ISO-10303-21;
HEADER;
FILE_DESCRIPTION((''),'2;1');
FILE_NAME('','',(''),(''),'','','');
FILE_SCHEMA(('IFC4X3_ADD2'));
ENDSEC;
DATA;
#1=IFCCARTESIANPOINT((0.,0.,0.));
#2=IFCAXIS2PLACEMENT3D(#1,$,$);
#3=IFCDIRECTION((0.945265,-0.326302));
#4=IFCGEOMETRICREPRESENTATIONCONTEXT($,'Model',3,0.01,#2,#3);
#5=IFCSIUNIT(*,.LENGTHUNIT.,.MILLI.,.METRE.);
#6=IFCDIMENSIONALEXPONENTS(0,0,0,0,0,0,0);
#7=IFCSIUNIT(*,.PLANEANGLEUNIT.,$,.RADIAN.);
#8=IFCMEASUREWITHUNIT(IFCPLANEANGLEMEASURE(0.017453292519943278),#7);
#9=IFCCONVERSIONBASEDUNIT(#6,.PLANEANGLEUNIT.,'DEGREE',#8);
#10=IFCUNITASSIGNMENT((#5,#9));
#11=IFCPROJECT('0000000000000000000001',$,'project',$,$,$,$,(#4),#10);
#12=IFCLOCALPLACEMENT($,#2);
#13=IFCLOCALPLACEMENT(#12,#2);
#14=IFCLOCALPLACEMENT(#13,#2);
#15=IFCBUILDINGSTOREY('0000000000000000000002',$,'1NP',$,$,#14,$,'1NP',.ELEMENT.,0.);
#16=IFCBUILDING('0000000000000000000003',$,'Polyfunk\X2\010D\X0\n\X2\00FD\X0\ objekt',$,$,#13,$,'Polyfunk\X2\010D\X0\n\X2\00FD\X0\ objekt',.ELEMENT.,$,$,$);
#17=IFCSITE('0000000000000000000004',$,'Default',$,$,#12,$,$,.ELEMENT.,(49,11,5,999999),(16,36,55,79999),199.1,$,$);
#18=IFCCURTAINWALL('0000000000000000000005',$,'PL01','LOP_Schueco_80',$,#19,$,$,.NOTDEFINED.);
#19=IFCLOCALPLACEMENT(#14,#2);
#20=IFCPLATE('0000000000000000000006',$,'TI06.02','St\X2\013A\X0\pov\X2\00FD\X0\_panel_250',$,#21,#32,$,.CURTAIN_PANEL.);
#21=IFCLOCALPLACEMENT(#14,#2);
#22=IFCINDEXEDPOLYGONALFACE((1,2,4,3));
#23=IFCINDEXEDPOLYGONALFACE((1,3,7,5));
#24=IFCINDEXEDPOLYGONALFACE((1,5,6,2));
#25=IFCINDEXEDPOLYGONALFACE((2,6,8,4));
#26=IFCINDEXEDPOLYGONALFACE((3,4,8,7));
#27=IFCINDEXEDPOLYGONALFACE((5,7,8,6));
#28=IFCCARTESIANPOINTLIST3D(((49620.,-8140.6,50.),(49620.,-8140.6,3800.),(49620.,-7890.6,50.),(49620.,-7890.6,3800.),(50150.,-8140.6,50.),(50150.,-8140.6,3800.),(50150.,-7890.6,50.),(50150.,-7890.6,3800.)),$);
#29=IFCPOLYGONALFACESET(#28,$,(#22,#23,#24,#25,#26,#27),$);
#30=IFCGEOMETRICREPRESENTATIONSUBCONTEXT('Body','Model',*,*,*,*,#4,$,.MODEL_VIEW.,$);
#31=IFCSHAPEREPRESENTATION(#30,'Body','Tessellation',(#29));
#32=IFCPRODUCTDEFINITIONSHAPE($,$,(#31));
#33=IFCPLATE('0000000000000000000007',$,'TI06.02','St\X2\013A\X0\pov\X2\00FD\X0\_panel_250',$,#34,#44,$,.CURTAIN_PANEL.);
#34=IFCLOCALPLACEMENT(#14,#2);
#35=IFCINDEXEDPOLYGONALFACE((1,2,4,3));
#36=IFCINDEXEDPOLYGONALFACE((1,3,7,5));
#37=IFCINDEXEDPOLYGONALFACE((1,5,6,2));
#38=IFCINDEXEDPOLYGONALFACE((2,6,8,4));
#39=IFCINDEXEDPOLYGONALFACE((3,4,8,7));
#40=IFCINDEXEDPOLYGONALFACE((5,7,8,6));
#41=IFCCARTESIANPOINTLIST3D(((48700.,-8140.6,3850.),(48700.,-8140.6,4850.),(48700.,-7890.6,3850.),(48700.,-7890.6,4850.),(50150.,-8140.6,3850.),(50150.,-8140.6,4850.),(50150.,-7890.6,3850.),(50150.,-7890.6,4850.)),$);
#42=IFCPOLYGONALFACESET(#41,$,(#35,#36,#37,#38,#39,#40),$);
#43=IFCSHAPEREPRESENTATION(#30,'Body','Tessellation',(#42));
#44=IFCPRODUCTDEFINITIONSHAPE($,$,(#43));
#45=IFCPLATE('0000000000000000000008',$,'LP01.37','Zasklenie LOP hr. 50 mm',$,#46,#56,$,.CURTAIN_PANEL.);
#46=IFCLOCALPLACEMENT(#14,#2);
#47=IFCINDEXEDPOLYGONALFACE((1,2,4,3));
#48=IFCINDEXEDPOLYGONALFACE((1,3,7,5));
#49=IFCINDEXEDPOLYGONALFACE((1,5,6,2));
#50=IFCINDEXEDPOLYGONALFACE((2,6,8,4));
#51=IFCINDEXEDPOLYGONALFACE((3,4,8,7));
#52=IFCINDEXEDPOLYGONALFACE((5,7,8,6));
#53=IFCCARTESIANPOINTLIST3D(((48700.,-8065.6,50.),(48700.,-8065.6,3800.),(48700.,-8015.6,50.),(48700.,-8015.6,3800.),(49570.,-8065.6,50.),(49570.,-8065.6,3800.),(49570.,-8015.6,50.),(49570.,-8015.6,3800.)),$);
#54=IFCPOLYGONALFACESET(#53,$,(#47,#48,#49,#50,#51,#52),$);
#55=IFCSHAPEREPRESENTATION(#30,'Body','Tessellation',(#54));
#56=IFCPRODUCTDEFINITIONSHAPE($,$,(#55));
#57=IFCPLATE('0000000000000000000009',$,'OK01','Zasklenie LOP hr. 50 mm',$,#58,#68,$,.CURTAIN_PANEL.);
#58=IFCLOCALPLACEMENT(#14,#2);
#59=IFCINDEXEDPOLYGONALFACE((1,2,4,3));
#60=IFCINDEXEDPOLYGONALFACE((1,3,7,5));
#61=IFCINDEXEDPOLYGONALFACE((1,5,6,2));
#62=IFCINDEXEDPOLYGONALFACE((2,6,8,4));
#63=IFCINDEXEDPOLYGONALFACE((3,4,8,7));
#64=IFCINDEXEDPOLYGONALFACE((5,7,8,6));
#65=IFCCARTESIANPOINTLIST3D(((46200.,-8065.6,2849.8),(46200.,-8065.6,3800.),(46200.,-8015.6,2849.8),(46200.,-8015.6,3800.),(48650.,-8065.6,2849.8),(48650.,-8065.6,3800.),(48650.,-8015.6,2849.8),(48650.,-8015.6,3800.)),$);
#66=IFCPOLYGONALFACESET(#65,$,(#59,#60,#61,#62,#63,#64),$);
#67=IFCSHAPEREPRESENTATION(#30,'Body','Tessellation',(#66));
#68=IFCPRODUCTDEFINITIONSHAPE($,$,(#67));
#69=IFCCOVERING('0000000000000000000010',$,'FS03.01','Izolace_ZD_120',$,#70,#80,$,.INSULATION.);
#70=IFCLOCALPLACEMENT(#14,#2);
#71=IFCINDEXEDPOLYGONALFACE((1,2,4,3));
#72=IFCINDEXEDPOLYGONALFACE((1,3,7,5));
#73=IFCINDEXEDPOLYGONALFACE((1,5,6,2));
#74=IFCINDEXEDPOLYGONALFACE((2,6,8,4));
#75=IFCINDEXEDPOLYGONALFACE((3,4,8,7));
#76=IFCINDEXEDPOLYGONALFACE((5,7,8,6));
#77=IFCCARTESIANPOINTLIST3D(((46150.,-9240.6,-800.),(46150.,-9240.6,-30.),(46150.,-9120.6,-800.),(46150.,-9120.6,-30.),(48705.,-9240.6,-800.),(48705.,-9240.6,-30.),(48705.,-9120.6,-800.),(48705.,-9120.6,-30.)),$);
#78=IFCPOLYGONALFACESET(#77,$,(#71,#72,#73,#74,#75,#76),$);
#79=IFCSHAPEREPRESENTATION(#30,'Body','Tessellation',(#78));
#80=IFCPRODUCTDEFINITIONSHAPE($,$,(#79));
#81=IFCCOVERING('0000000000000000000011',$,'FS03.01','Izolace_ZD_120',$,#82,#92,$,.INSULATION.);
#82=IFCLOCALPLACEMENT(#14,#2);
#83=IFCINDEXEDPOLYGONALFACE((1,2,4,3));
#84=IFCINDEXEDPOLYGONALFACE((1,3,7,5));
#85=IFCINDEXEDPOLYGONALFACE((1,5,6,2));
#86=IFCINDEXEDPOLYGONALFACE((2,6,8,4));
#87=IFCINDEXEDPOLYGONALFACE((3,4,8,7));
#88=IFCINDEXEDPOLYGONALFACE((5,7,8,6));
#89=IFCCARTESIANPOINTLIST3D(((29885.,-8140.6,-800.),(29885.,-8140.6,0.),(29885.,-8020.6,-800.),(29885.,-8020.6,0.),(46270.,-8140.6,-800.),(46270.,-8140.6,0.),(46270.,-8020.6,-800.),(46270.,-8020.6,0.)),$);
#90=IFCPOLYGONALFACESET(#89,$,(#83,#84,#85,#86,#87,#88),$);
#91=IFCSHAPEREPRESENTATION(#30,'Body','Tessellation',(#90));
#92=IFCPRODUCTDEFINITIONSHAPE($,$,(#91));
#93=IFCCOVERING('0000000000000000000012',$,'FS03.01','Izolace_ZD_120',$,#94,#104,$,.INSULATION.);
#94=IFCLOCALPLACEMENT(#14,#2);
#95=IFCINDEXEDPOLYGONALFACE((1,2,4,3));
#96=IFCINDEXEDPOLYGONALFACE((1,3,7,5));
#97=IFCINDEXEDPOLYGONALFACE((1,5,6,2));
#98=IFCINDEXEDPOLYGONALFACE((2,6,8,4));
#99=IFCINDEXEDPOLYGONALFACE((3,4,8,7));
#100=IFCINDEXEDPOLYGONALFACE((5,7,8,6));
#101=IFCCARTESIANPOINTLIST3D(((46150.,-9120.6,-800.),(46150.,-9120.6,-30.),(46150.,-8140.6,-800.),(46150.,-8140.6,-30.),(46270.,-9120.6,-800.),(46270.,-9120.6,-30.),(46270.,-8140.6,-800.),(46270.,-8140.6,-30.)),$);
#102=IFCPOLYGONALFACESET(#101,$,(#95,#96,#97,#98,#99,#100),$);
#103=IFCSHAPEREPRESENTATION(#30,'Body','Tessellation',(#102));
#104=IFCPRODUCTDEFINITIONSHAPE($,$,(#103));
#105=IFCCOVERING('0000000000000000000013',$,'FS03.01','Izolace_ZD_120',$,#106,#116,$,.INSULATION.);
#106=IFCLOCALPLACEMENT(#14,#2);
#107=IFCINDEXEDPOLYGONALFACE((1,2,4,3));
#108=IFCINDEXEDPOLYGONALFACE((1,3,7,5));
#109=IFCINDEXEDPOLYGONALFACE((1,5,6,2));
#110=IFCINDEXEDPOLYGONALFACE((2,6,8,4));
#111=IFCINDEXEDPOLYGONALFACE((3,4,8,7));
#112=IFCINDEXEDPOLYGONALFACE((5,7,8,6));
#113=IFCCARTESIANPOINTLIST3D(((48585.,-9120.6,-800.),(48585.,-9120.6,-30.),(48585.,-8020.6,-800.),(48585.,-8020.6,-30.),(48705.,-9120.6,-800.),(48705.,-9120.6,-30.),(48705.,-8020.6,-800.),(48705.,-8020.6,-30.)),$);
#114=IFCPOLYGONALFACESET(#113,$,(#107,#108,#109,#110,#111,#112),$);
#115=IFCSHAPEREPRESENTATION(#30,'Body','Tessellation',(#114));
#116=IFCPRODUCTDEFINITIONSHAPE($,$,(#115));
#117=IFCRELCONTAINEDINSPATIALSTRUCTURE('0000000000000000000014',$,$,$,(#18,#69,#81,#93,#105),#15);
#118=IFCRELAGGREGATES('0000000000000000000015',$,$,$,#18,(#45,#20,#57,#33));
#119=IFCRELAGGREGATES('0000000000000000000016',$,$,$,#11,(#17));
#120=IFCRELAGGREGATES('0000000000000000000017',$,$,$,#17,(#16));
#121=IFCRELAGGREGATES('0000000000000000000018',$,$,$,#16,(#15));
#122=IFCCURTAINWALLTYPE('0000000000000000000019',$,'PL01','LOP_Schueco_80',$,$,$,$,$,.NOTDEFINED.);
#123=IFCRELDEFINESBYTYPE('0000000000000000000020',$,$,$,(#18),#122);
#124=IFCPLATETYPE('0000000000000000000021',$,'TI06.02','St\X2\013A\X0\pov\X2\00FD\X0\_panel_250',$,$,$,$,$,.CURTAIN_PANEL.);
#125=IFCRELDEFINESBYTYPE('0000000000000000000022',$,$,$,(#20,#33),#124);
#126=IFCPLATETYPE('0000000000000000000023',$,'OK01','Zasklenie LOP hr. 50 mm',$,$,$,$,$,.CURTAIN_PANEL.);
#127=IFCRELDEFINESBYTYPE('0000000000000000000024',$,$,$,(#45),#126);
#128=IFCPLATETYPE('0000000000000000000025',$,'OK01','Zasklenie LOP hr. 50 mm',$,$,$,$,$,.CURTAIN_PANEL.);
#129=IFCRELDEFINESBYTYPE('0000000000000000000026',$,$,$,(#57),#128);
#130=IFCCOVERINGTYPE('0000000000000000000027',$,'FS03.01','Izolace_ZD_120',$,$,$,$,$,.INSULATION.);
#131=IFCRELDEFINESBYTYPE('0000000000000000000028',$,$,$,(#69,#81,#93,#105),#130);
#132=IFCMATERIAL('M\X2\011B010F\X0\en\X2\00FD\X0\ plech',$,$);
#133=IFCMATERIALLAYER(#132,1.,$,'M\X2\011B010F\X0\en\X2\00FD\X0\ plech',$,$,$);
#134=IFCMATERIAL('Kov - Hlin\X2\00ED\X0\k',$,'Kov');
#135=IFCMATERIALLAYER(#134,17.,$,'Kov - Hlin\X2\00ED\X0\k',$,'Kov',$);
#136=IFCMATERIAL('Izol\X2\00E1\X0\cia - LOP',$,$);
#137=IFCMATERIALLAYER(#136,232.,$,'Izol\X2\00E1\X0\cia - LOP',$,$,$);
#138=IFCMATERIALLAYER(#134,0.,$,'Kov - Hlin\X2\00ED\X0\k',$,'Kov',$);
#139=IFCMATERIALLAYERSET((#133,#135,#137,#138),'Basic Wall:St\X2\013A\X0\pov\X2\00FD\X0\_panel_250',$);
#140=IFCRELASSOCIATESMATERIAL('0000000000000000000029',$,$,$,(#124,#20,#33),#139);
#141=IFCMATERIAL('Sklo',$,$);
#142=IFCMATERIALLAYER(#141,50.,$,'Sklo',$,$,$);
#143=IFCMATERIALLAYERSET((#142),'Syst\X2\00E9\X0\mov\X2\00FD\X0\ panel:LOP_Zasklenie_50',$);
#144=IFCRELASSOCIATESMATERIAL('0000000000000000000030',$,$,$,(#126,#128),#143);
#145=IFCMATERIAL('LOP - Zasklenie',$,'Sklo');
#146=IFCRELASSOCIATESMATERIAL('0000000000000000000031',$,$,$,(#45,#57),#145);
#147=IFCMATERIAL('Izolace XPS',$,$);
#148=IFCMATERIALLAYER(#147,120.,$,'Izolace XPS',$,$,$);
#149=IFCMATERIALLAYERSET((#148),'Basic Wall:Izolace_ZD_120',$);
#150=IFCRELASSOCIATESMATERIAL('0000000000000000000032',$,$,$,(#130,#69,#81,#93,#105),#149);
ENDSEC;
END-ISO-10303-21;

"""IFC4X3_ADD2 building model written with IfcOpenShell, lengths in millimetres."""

from ifc_helpers import new_model, entity, si_unit, converted_unit, direction, frame, frame_2d, origin, origin_2d_with_axis, place, context, subcontext, project, spatial, rectangle, extrude, source, transform, mapped, material, layer, layer_set, layer_usage, type_object, type_shapes, element, aggregate, save


model = new_model("IFC4X3_ADD2")

# Units and contexts
model_context = context("Model", 3, precision=0.01, world=origin(), true_north=direction((0.945265, -0.326302)))
body_context = subcontext(model_context, "Body", "Model", "MODEL_VIEW")
ifc_project = project(units=[si_unit("LENGTHUNIT", "METRE", prefix="MILLI"), converted_unit("PLANEANGLEUNIT", "DEGREE", entity("IfcPlaneAngleMeasure", 0.017453292519943278), si_unit("PLANEANGLEUNIT", "RADIAN"), dimensions=[0, 0, 0, 0, 0, 0, 0])], contexts=[model_context])

# Site, building, storey
site_placement = place(None, origin())
site = spatial("IfcSite", under=ifc_project, at=site_placement, Name="Default", CompositionType="ELEMENT", RefLatitude=(49, 11, 5, 999999), RefLongitude=(16, 36, 55, 79999), RefElevation=199.1)
building_placement = place(site_placement, origin())
building = spatial("IfcBuilding", under=site, at=building_placement, Name="Polyfunkčný objekt", LongName="Polyfunkčný objekt", CompositionType="ELEMENT")
storey_placement = place(building_placement, origin())
storey = spatial("IfcBuildingStorey", under=building, at=storey_placement, Name="1NP", LongName="1NP", CompositionType="ELEMENT", Elevation=0.0)

# Curtain wall, plates
curtain_wall_type = type_object("IfcCurtainWallType", Name="PL01", Description="LOP_Schueco_80", PredefinedType="NOTDEFINED")
curtain_wall_placement = place(storey_placement, origin())
curtain_wall = element("IfcCurtainWall", 1, at=curtain_wall_placement, inside=storey, type_object=curtain_wall_type, Name="PL01", Description="LOP_Schueco_80", PredefinedType="NOTDEFINED")
ifc_material_1 = material(Name="Měďený plech")
ifc_layer_1 = layer(ifc_material_1, 1.0, Name="Měďený plech")
ifc_material_2 = material(Name="Kov - Hliník", Category="Kov")
ifc_layer_2 = layer(ifc_material_2, 17.0, Name="Kov - Hliník", Category="Kov")
ifc_material_3 = material(Name="Izolácia - LOP")
ifc_layer_3 = layer(ifc_material_3, 232.0, Name="Izolácia - LOP")
ifc_layer_4 = layer(ifc_material_2, 0.0, Name="Kov - Hliník", Category="Kov")
ifc_layer_set_1 = layer_set([ifc_layer_1, ifc_layer_2, ifc_layer_3, ifc_layer_4], Name="Basic Wall:Stĺpový_panel_250")
ifc_layer_usage_1 = layer_usage(ifc_layer_set_1, "AXIS2", "POSITIVE", -125.0)
plate_type_1 = type_object("IfcPlateType", Name="TI06.02", Description="Stĺpový_panel_250", PredefinedType="CURTAIN_PANEL", material=ifc_layer_set_1)
plate_1_placement = place(storey_placement, frame((49620.0, -8015.6, 50.0)))
plate_1 = element("IfcPlate", 2, at=plate_1_placement, type_object=plate_type_1, material=ifc_layer_usage_1, Name="TI06.02", Description="Stĺpový_panel_250", PredefinedType="CURTAIN_PANEL", context=body_context, shape_type="SweptSolid", body=[
    extrude(rectangle(XDim=250.0, YDim=530.0, at=frame_2d((0.0, 0.0), x_axis=(1.0, 0.0))), frame((265.0, 0.0, 0.0), z_axis=(0.0, 0.0, 1.0), x_axis=(0.0, 1.0, 0.0)), (0.0, 0.0, 1.0), 3750.0),
])
ifc_layer_usage_2 = layer_usage(ifc_layer_set_1, "AXIS2", "POSITIVE", -125.0)
plate_2_placement = place(storey_placement, frame((48700.0, -8015.6, 3850.0)))
plate_2 = element("IfcPlate", 3, at=plate_2_placement, type_object=plate_type_1, material=ifc_layer_usage_2, Name="TI06.02", Description="Stĺpový_panel_250", PredefinedType="CURTAIN_PANEL", context=body_context, shape_type="SweptSolid", body=[
    extrude(rectangle(XDim=250.0, YDim=1450.0, at=frame_2d((0.0, 0.0), x_axis=(1.0, 0.0))), frame((725.0, 0.0, 0.0), z_axis=(0.0, 0.0, 1.0), x_axis=(0.0, 1.0, 0.0)), (0.0, 0.0, 1.0), 1000.0),
])
ifc_material_4 = material(Name="LOP - Zasklenie", Category="Sklo")
ifc_material_5 = material(Name="Sklo")
ifc_layer_5 = layer(ifc_material_5, 50.0, Name="Sklo")
ifc_layer_set_2 = layer_set([ifc_layer_5], Name="Systémový panel:LOP_Zasklenie_50")
plate_type_2 = type_object("IfcPlateType", Name="OK01", Description="Zasklenie LOP hr. 50 mm", PredefinedType="CURTAIN_PANEL", material=ifc_layer_set_2)
shared_shape_1 = source(origin(), body_context, "Body", "SweptSolid", [
    extrude(rectangle(XDim=3750.0, YDim=870.0, at=frame_2d((-331.2, 0.0), x_axis=(1.0, 0.0))), frame((0.0, -50.0, 2206.2), z_axis=(0.0, 1.0, 0.0), x_axis=(0.0, 0.0, 1.0)), (0.0, 0.0, 1.0), 50.0),
])
type_shapes(plate_type_2, [shared_shape_1])
plate_3_placement = place(curtain_wall_placement, frame((49135.0, -8015.6, 50.0)))
plate_3 = element("IfcPlate", 4, at=plate_3_placement, type_object=plate_type_2, material=ifc_material_4, Name="LP01.37", Description="Zasklenie LOP hr. 50 mm", PredefinedType="CURTAIN_PANEL", context=body_context, shape_type="MappedRepresentation", body=[
    mapped(shared_shape_1, transform((0.0, 0.0, 0.0), scale=1.0)),
])
plate_type_3 = type_object("IfcPlateType", Name="OK01", Description="Zasklenie LOP hr. 50 mm", PredefinedType="CURTAIN_PANEL", material=ifc_layer_set_2)
shared_shape_2 = source(origin(), body_context, "Body", "SweptSolid", [
    extrude(rectangle(XDim=50.0, YDim=2450.0, at=origin_2d_with_axis()), frame((0.0, -25.0, 0.0), z_axis=(0.0, 0.0, 1.0), x_axis=(0.0, 1.0, 0.0)), (0.0, 0.0, 1.0), 950.2),
])
type_shapes(plate_type_3, [shared_shape_2])
plate_4_placement = place(curtain_wall_placement, frame((47425.0, -8015.6, 2849.8)))
plate_4 = element("IfcPlate", 5, at=plate_4_placement, type_object=plate_type_3, material=ifc_material_4, Name="OK01", Description="Zasklenie LOP hr. 50 mm", PredefinedType="CURTAIN_PANEL", context=body_context, shape_type="MappedRepresentation", body=[
    mapped(shared_shape_2, transform((0.0, 0.0, 0.0), scale=1.0)),
])
aggregate(curtain_wall, [plate_3, plate_1, plate_4, plate_2])

# Coverings
ifc_material_6 = material(Name="Izolace XPS")
ifc_layer_6 = layer(ifc_material_6, 120.0, Name="Izolace XPS")
ifc_layer_set_3 = layer_set([ifc_layer_6], Name="Basic Wall:Izolace_ZD_120")
covering_type = type_object("IfcCoveringType", Name="FS03.01", Description="Izolace_ZD_120", PredefinedType="INSULATION", material=ifc_layer_set_3)
covering_1_placement = place(storey_placement, frame((48705.0, -9180.6, -800.0), z_axis=(0.0, 0.0, 1.0), x_axis=(-1.0, 0.0, 0.0)))
element("IfcCovering", 6, at=covering_1_placement, inside=storey, type_object=covering_type, material=ifc_layer_set_3, Name="FS03.01", Description="Izolace_ZD_120", PredefinedType="INSULATION", context=body_context, shape_type="SweptSolid", body=[
    extrude(rectangle(XDim=2555.0, YDim=120.0, at=frame_2d((1277.5, 0.0), x_axis=(-1.0, 0.0))), origin(), (0.0, 0.0, 1.0), 770.0),
])
covering_2_placement = place(storey_placement, frame((46270.0, -8080.6, -800.0), z_axis=(0.0, 0.0, 1.0), x_axis=(-1.0, 0.0, 0.0)))
element("IfcCovering", 7, at=covering_2_placement, inside=storey, type_object=covering_type, material=ifc_layer_set_3, Name="FS03.01", Description="Izolace_ZD_120", PredefinedType="INSULATION", context=body_context, shape_type="SweptSolid", body=[
    extrude(rectangle(XDim=16385.0, YDim=120.0, at=frame_2d((8192.5, 0.0), x_axis=(-1.0, 0.0))), origin(), (0.0, 0.0, 1.0), 800.0),
])
covering_3_placement = place(storey_placement, frame((46210.0, -9120.6, -800.0), z_axis=(0.0, 0.0, 1.0), x_axis=(0.0, 1.0, 0.0)))
element("IfcCovering", 8, at=covering_3_placement, inside=storey, type_object=covering_type, material=ifc_layer_set_3, Name="FS03.01", Description="Izolace_ZD_120", PredefinedType="INSULATION", context=body_context, shape_type="SweptSolid", body=[
    extrude(rectangle(XDim=980.0, YDim=120.0, at=frame_2d((490.0, 0.0), x_axis=(-1.0, 0.0))), origin(), (0.0, 0.0, 1.0), 770.0),
])
covering_4_placement = place(storey_placement, frame((48645.0, -9120.6, -800.0), z_axis=(0.0, 0.0, 1.0), x_axis=(0.0, 1.0, 0.0)))
element("IfcCovering", 9, at=covering_4_placement, inside=storey, type_object=covering_type, material=ifc_layer_set_3, Name="FS03.01", Description="Izolace_ZD_120", PredefinedType="INSULATION", context=body_context, shape_type="SweptSolid", body=[
    extrude(rectangle(XDim=1100.0, YDim=120.0, at=frame_2d((550.0, 0.0), x_axis=(-1.0, 0.0))), origin(), (0.0, 0.0, 1.0), 770.0),
])

save(model, "model.ifc")
